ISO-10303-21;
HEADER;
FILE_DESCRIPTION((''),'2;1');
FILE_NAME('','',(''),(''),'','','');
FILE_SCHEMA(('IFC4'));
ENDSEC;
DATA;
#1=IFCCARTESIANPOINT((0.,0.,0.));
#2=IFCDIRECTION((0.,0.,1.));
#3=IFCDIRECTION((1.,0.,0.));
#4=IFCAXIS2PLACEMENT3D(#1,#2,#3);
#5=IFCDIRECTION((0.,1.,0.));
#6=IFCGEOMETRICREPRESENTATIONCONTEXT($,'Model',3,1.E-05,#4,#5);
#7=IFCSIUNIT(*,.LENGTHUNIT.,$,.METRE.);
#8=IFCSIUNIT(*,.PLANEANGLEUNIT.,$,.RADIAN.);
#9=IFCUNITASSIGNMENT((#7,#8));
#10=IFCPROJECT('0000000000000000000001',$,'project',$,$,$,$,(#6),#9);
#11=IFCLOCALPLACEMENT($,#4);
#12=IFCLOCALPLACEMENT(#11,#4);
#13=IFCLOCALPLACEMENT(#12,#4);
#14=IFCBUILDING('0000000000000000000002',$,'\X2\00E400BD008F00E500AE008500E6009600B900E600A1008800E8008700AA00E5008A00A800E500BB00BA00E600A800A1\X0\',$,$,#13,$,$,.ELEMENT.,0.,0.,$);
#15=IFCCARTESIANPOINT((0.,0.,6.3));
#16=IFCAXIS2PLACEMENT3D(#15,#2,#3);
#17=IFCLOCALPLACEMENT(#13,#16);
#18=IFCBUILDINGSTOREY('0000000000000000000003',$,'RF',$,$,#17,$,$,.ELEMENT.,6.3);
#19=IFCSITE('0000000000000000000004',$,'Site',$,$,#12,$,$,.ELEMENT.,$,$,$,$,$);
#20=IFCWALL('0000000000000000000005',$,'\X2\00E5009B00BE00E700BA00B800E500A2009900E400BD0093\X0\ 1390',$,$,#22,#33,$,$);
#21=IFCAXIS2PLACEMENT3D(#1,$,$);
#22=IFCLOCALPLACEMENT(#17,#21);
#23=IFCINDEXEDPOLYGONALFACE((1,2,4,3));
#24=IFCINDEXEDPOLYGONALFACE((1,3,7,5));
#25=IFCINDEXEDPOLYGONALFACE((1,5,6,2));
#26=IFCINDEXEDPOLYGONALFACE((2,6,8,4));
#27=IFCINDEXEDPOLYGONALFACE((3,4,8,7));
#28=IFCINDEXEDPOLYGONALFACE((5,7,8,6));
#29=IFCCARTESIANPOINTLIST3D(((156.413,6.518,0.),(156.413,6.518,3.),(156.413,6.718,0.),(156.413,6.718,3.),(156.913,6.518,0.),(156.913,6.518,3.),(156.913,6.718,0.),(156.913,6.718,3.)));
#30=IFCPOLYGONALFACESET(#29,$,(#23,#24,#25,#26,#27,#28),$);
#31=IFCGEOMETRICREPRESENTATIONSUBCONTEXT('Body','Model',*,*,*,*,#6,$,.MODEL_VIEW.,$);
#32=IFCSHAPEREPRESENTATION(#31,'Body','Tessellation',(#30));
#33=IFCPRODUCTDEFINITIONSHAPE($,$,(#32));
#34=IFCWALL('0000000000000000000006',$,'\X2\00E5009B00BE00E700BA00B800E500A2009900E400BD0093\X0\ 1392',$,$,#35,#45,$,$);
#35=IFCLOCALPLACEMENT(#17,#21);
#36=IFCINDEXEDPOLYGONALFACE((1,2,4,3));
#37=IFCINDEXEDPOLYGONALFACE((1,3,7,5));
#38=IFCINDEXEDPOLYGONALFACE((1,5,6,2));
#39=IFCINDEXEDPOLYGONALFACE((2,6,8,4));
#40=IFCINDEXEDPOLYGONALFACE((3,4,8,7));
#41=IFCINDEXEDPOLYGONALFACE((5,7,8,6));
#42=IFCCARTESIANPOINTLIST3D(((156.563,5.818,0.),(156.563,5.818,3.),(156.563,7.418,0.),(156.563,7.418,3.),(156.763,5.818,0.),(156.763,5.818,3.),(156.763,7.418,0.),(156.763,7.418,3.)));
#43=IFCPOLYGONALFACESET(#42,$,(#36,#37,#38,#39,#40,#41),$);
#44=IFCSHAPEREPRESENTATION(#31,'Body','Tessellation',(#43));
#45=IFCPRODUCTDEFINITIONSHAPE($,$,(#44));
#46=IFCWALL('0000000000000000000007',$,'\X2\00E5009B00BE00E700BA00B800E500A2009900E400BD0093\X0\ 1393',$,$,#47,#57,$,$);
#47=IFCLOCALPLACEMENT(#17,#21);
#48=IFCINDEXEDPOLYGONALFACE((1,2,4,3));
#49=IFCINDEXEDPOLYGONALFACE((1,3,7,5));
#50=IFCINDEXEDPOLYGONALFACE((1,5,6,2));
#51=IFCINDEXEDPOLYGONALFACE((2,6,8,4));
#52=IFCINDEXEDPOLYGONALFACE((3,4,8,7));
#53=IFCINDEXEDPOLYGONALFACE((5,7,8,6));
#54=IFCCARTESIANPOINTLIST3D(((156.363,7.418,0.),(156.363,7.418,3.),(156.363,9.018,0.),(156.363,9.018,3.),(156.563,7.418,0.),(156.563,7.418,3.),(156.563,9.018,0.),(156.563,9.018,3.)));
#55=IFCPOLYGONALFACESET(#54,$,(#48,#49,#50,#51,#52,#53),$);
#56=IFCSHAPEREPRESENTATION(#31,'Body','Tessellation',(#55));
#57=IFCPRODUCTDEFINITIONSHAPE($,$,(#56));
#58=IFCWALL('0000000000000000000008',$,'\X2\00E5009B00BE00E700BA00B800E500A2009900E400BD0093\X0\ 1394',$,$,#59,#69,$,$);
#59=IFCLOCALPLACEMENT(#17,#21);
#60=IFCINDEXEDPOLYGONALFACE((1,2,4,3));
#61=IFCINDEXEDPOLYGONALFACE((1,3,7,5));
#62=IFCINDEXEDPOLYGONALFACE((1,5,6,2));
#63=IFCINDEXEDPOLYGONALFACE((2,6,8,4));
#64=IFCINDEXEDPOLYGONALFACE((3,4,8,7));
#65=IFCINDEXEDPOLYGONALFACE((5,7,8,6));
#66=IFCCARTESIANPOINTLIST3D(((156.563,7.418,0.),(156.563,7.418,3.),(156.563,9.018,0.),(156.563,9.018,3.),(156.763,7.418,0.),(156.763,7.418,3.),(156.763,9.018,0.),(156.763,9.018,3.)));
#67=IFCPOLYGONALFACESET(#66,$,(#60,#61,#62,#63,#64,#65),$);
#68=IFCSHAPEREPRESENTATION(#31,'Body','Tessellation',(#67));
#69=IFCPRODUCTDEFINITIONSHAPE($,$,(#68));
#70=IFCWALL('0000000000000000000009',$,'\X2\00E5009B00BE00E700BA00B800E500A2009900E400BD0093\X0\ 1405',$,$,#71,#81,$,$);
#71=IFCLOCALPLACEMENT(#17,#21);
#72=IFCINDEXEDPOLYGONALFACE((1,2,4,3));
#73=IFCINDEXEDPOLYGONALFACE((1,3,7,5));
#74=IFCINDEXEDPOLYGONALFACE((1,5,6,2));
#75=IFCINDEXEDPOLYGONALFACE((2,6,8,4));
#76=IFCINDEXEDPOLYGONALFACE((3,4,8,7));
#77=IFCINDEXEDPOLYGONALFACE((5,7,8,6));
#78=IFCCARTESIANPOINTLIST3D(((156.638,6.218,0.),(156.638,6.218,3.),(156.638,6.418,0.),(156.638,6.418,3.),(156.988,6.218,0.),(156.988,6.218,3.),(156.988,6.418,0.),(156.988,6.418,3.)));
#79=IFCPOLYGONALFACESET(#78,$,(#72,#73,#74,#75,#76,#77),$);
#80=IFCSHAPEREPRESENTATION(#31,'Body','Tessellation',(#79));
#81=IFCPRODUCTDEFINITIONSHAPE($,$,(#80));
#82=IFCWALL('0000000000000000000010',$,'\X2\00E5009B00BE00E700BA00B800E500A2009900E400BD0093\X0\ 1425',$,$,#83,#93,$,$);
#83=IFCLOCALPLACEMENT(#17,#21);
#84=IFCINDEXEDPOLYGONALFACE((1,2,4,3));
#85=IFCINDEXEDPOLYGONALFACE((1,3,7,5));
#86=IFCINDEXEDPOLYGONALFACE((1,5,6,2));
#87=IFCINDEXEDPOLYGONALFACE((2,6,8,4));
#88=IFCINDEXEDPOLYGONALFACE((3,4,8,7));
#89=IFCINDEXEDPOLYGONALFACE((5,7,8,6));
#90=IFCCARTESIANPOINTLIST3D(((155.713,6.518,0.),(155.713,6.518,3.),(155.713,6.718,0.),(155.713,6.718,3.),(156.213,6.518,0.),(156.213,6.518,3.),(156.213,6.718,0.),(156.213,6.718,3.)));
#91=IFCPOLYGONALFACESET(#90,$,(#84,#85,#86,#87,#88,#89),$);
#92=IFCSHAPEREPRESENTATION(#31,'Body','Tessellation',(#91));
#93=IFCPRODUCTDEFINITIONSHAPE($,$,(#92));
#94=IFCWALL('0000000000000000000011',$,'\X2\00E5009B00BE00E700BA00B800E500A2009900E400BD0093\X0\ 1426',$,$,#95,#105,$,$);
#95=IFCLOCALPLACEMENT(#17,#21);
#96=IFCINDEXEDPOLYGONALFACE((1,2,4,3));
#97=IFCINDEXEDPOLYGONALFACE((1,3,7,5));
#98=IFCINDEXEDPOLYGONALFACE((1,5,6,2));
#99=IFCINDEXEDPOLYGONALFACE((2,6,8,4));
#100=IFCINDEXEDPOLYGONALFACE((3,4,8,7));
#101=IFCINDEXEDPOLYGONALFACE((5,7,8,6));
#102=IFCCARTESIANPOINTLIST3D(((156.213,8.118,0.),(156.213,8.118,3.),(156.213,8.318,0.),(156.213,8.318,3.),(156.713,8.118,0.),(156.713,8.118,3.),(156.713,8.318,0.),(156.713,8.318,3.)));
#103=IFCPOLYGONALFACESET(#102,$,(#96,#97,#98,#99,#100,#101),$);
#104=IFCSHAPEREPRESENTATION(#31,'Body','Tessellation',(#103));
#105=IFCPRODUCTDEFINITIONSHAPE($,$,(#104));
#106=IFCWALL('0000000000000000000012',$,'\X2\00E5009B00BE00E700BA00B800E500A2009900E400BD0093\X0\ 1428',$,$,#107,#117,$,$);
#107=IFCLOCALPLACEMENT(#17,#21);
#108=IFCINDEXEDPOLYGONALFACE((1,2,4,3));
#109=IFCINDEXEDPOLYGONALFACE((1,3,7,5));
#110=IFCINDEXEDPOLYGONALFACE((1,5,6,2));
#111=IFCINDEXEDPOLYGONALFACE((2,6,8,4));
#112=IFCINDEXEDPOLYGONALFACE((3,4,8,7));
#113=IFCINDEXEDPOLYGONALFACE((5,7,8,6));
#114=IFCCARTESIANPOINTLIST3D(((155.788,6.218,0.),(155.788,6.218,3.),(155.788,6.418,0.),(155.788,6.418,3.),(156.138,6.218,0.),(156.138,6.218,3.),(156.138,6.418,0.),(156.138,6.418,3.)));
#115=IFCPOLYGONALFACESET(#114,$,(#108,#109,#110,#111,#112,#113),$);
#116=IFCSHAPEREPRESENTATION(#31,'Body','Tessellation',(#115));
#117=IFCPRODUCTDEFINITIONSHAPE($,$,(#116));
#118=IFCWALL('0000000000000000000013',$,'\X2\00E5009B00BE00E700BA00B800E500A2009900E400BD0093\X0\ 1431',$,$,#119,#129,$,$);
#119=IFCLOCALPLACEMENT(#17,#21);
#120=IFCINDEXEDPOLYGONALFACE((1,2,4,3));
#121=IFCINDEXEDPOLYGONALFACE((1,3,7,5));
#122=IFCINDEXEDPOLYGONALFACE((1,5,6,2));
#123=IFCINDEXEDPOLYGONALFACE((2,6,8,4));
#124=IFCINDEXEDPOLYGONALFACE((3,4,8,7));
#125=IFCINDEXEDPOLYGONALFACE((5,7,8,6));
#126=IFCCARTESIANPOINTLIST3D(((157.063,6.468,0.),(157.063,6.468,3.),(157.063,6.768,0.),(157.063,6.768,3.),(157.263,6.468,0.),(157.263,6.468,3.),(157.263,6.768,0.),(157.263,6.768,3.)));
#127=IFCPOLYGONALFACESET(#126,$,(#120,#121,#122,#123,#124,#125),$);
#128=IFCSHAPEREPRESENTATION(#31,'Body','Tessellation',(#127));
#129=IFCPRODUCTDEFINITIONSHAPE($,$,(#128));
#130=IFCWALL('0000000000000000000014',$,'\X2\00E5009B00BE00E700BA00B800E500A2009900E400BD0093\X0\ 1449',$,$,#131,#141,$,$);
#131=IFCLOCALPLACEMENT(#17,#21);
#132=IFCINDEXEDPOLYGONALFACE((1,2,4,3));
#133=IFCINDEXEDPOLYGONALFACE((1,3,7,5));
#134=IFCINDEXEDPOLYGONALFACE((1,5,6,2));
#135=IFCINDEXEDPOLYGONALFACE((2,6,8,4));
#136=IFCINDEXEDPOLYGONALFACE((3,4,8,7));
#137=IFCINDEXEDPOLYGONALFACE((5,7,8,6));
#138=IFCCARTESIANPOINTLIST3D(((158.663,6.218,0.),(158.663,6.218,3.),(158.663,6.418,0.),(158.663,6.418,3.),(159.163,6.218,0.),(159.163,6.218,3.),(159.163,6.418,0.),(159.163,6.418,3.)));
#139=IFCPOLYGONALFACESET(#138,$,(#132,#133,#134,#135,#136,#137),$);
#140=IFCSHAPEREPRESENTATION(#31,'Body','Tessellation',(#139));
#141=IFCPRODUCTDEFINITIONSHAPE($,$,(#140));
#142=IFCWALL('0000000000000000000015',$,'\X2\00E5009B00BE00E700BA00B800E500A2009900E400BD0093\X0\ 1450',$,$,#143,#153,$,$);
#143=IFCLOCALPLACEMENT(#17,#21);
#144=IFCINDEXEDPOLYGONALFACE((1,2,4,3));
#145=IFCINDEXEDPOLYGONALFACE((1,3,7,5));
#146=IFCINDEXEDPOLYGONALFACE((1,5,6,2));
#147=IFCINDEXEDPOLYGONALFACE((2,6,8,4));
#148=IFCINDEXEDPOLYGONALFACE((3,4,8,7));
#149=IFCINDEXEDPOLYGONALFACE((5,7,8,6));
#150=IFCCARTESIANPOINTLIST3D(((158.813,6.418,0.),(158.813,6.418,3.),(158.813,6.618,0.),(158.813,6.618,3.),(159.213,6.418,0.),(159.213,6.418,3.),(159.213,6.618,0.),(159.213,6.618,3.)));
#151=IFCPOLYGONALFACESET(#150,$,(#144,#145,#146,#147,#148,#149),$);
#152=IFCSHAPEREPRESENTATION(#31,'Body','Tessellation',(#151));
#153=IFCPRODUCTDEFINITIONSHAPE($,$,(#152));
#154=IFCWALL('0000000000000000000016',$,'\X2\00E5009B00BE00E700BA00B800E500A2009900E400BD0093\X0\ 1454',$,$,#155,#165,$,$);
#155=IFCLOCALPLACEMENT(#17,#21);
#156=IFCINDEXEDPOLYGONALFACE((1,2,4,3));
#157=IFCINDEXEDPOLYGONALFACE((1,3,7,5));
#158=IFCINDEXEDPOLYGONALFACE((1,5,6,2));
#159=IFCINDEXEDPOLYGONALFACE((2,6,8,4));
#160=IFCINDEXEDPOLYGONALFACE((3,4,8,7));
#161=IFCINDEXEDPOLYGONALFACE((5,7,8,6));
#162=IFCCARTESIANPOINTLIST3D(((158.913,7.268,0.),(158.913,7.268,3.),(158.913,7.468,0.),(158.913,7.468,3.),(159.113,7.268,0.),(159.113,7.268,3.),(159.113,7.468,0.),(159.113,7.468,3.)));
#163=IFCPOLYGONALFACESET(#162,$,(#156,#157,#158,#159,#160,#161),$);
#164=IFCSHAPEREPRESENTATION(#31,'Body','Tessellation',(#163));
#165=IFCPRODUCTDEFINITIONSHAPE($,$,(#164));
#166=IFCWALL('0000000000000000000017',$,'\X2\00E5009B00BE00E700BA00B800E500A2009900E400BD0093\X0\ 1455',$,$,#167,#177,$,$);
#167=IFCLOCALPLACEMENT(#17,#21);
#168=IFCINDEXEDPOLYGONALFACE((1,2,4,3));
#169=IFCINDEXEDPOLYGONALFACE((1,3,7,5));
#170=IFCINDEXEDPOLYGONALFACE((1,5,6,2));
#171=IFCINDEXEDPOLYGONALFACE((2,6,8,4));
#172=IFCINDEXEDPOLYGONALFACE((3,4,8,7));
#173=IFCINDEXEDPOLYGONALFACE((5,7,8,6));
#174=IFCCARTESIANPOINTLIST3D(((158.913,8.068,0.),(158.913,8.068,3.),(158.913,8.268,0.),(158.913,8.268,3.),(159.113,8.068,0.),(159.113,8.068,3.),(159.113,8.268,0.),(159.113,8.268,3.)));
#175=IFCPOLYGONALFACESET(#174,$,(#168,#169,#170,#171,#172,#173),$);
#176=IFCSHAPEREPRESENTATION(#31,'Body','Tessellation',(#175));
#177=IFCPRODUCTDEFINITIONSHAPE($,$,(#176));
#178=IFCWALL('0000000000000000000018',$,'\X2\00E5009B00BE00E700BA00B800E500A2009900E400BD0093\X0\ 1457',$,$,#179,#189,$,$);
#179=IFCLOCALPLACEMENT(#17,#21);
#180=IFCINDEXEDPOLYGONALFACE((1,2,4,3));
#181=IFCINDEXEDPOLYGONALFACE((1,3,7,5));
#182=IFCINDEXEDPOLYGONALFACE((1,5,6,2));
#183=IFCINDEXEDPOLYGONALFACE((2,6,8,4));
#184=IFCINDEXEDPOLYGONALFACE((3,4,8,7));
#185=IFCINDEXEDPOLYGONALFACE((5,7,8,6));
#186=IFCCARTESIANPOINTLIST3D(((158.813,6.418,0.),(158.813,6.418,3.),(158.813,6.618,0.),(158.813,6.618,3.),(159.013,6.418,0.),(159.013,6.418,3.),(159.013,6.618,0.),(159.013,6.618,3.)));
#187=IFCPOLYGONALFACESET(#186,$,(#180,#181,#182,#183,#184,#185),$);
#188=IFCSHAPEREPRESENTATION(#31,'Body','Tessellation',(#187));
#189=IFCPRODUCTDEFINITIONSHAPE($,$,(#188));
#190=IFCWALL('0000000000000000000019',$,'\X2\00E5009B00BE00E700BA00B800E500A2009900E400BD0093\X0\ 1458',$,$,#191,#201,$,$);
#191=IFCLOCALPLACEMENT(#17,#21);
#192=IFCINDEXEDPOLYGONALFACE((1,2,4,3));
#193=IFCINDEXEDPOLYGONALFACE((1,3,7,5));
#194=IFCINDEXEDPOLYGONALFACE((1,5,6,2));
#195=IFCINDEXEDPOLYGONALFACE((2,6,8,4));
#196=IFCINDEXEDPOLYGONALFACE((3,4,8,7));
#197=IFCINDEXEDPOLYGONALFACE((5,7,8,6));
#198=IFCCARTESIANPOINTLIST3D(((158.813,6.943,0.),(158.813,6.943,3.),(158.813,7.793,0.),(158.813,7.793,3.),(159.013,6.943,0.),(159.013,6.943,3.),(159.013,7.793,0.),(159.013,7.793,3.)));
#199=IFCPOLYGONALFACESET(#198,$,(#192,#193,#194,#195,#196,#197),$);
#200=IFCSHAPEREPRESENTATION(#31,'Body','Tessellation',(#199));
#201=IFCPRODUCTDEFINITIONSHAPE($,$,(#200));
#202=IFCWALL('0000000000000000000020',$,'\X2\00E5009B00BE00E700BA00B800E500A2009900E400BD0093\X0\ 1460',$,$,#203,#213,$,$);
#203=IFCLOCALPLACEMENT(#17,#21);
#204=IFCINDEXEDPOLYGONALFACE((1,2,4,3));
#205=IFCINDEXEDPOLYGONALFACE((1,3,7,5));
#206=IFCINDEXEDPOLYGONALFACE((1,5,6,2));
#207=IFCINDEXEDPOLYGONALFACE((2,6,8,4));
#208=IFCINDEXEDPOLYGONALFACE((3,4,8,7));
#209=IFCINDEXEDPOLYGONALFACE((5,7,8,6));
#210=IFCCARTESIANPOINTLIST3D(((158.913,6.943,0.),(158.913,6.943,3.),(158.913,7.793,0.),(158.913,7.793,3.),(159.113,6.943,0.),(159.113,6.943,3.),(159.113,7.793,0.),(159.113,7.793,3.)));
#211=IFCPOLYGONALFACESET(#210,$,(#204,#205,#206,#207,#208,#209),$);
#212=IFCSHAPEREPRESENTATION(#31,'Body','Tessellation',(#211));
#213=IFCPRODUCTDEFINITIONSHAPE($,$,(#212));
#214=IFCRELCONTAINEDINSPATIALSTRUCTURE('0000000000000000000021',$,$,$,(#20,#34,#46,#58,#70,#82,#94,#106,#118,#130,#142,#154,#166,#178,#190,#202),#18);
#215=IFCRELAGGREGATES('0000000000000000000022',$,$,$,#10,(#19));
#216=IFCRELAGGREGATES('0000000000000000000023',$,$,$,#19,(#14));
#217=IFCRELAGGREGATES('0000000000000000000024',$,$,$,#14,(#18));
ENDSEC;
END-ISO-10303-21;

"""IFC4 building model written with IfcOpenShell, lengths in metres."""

from ifc_helpers import new_model, si_unit, direction, frame, frame_2d, origin_with_axes, place, context, subcontext, project, spatial, rectangle, extrude, element, save


model = new_model("IFC4")

# Units and contexts
model_context = context("Model", 3, precision=1e-05, world=origin_with_axes(), true_north=direction((0.0, 1.0, 0.0)))
body_context = subcontext(model_context, "Body", "Model", "MODEL_VIEW")
ifc_project = project(units=[si_unit("LENGTHUNIT", "METRE"), si_unit("PLANEANGLEUNIT", "RADIAN")], contexts=[model_context])

# Site, building, storey
placement = place(None, origin_with_axes())
site_placement = place(placement, origin_with_axes())
site = spatial("IfcSite", under=ifc_project, at=site_placement, Name="Site", CompositionType="ELEMENT")
building_placement = place(site_placement, origin_with_axes())
building = spatial("IfcBuilding", under=site, at=building_placement, Name="ä½\u008få®\u0085æ\u0096¹æ¡\u0088è\u0087ªå\u008a¨å»ºæ¨¡", CompositionType="ELEMENT", ElevationOfRefHeight=0.0, ElevationOfTerrain=0.0)
storey_placement = place(building_placement, frame((0.0, 0.0, 6.3), z_axis=(0.0, 0.0, 1.0), x_axis=(1.0, 0.0, 0.0)))
storey = spatial("IfcBuildingStorey", under=building, at=storey_placement, Name="RF", CompositionType="ELEMENT", Elevation=6.3)

# Walls
wall_1_placement = place(storey_placement, frame((156.663, 6.618, 0.0), z_axis=(0.0, 0.0, 1.0), x_axis=(1.0, 0.0, 0.0)))
element("IfcWall", 1, at=wall_1_placement, inside=storey, Name="å\u009b¾çº¸å¢\u0099ä½\u0093 1390", context=body_context, shape_type="SweptSolid", body=[
    extrude(rectangle(XDim=0.5, YDim=0.2, at=frame_2d((0.0, 0.0), x_axis=(1.0, 0.0, 0.0))), frame((0.0, 0.0, 0.0), z_axis=(0.0, 0.0, 1.0)), (0.0, 0.0, 1.0), 3.0),
])
for number, where, z_axis, x_axis, name in (
    (2, (156.663, 6.618, 0.0), (0.0, 0.0, 1.0), (0.0, 1.0, 0.0), "å\u009b¾çº¸å¢\u0099ä½\u0093 1392"),
    (3, (156.463, 8.218, 0.0), (0.0, 0.0, 1.0), (0.0, -1.0, 0.0), "å\u009b¾çº¸å¢\u0099ä½\u0093 1393"),
    (4, (156.663, 8.218, 0.0), (0.0, 0.0, 1.0), (0.0, -1.0, 0.0), "å\u009b¾çº¸å¢\u0099ä½\u0093 1394"),
):
    element("IfcWall", number, at=place(storey_placement, frame(where, z_axis=z_axis, x_axis=x_axis)), inside=storey, Name=name, context=body_context, shape_type="SweptSolid", body=[
        extrude(rectangle(XDim=1.6, YDim=0.2, at=frame_2d((0.0, 0.0), x_axis=(1.0, 0.0, 0.0))), frame((0.0, 0.0, 0.0), z_axis=(0.0, 0.0, 1.0)), (0.0, 0.0, 1.0), 3.0),
    ])
wall_2_placement = place(storey_placement, frame((156.813, 6.318, 0.0), z_axis=(0.0, 0.0, 1.0), x_axis=(1.0, 0.0, 0.0)))
element("IfcWall", 5, at=wall_2_placement, inside=storey, Name="å\u009b¾çº¸å¢\u0099ä½\u0093 1405", context=body_context, shape_type="SweptSolid", body=[
    extrude(rectangle(XDim=0.35, YDim=0.2, at=frame_2d((0.0, 0.0), x_axis=(1.0, 0.0, 0.0))), frame((0.0, 0.0, 0.0), z_axis=(0.0, 0.0, 1.0)), (0.0, 0.0, 1.0), 3.0),
])
for number, where, z_axis, x_axis, name in (
    (6, (155.963, 6.618, 0.0), (0.0, 0.0, 1.0), (1.0, 0.0, 0.0), "å\u009b¾çº¸å¢\u0099ä½\u0093 1425"),
    (7, (156.463, 8.218, 0.0), (0.0, 0.0, 1.0), (-1.0, 0.0, 0.0), "å\u009b¾çº¸å¢\u0099ä½\u0093 1426"),
):
    element("IfcWall", number, at=place(storey_placement, frame(where, z_axis=z_axis, x_axis=x_axis)), inside=storey, Name=name, context=body_context, shape_type="SweptSolid", body=[
        extrude(rectangle(XDim=0.5, YDim=0.2, at=frame_2d((0.0, 0.0), x_axis=(1.0, 0.0, 0.0))), frame((0.0, 0.0, 0.0), z_axis=(0.0, 0.0, 1.0)), (0.0, 0.0, 1.0), 3.0),
    ])
for number, where, z_axis, x_axis, name in (
    (8, (155.963, 6.318, 0.0), (0.0, 0.0, 1.0), (1.0, 0.0, 0.0), "å\u009b¾çº¸å¢\u0099ä½\u0093 1428"),
):
    element("IfcWall", number, at=place(storey_placement, frame(where, z_axis=z_axis, x_axis=x_axis)), inside=storey, Name=name, context=body_context, shape_type="SweptSolid", body=[
        extrude(rectangle(XDim=0.35, YDim=0.2, at=frame_2d((0.0, 0.0), x_axis=(1.0, 0.0, 0.0))), frame((0.0, 0.0, 0.0), z_axis=(0.0, 0.0, 1.0)), (0.0, 0.0, 1.0), 3.0),
    ])
wall_3_placement = place(storey_placement, frame((157.163, 6.618, 0.0), z_axis=(0.0, 0.0, 1.0), x_axis=(0.0, -1.0, 0.0)))
element("IfcWall", 9, at=wall_3_placement, inside=storey, Name="å\u009b¾çº¸å¢\u0099ä½\u0093 1431", context=body_context, shape_type="SweptSolid", body=[
    extrude(rectangle(XDim=0.3, YDim=0.2, at=frame_2d((0.0, 0.0), x_axis=(1.0, 0.0, 0.0))), frame((0.0, 0.0, 0.0), z_axis=(0.0, 0.0, 1.0)), (0.0, 0.0, 1.0), 3.0),
])
for number, where, z_axis, x_axis, name in (
    (10, (158.913, 6.318, 0.0), (0.0, 0.0, 1.0), (1.0, 0.0, 0.0), "å\u009b¾çº¸å¢\u0099ä½\u0093 1449"),
):
    element("IfcWall", number, at=place(storey_placement, frame(where, z_axis=z_axis, x_axis=x_axis)), inside=storey, Name=name, context=body_context, shape_type="SweptSolid", body=[
        extrude(rectangle(XDim=0.5, YDim=0.2, at=frame_2d((0.0, 0.0), x_axis=(1.0, 0.0, 0.0))), frame((0.0, 0.0, 0.0), z_axis=(0.0, 0.0, 1.0)), (0.0, 0.0, 1.0), 3.0),
    ])
wall_4_placement = place(storey_placement, frame((159.013, 6.518, 0.0), z_axis=(0.0, 0.0, 1.0), x_axis=(1.0, 0.0, 0.0)))
element("IfcWall", 11, at=wall_4_placement, inside=storey, Name="å\u009b¾çº¸å¢\u0099ä½\u0093 1450", context=body_context, shape_type="SweptSolid", body=[
    extrude(rectangle(XDim=0.4, YDim=0.2, at=frame_2d((0.0, 0.0), x_axis=(1.0, 0.0, 0.0))), frame((0.0, 0.0, 0.0), z_axis=(0.0, 0.0, 1.0)), (0.0, 0.0, 1.0), 3.0),
])
for number, where, z_axis, x_axis, name in (
    (12, (159.013, 7.368, 0.0), (0.0, 0.0, 1.0), (-1.0, 0.0, 0.0), "å\u009b¾çº¸å¢\u0099ä½\u0093 1454"),
    (13, (159.013, 8.168, 0.0), (0.0, 0.0, 1.0), (-1.0, 0.0, 0.0), "å\u009b¾çº¸å¢\u0099ä½\u0093 1455"),
    (14, (158.913, 6.518, 0.0), (0.0, 0.0, 1.0), (0.0, -1.0, 0.0), "å\u009b¾çº¸å¢\u0099ä½\u0093 1457"),
):
    element("IfcWall", number, at=place(storey_placement, frame(where, z_axis=z_axis, x_axis=x_axis)), inside=storey, Name=name, context=body_context, shape_type="SweptSolid", body=[
        extrude(rectangle(XDim=0.2, YDim=0.2, at=frame_2d((0.0, 0.0), x_axis=(1.0, 0.0, 0.0))), frame((0.0, 0.0, 0.0), z_axis=(0.0, 0.0, 1.0)), (0.0, 0.0, 1.0), 3.0),
    ])
for number, where, z_axis, x_axis, name in (
    (15, (158.913, 7.368, 0.0), (0.0, 0.0, 1.0), (0.0, -1.0, 0.0), "å\u009b¾çº¸å¢\u0099ä½\u0093 1458"),
    (16, (159.013, 7.368, 0.0), (0.0, 0.0, 1.0), (0.0, -1.0, 0.0), "å\u009b¾çº¸å¢\u0099ä½\u0093 1460"),
):
    element("IfcWall", number, at=place(storey_placement, frame(where, z_axis=z_axis, x_axis=x_axis)), inside=storey, Name=name, context=body_context, shape_type="SweptSolid", body=[
        extrude(rectangle(XDim=0.85, YDim=0.2, at=frame_2d((0.0, 0.0), x_axis=(1.0, 0.0, 0.0))), frame((0.0, 0.0, 0.0), z_axis=(0.0, 0.0, 1.0)), (0.0, 0.0, 1.0), 3.0),
    ])

save(model, "model.ifc")
